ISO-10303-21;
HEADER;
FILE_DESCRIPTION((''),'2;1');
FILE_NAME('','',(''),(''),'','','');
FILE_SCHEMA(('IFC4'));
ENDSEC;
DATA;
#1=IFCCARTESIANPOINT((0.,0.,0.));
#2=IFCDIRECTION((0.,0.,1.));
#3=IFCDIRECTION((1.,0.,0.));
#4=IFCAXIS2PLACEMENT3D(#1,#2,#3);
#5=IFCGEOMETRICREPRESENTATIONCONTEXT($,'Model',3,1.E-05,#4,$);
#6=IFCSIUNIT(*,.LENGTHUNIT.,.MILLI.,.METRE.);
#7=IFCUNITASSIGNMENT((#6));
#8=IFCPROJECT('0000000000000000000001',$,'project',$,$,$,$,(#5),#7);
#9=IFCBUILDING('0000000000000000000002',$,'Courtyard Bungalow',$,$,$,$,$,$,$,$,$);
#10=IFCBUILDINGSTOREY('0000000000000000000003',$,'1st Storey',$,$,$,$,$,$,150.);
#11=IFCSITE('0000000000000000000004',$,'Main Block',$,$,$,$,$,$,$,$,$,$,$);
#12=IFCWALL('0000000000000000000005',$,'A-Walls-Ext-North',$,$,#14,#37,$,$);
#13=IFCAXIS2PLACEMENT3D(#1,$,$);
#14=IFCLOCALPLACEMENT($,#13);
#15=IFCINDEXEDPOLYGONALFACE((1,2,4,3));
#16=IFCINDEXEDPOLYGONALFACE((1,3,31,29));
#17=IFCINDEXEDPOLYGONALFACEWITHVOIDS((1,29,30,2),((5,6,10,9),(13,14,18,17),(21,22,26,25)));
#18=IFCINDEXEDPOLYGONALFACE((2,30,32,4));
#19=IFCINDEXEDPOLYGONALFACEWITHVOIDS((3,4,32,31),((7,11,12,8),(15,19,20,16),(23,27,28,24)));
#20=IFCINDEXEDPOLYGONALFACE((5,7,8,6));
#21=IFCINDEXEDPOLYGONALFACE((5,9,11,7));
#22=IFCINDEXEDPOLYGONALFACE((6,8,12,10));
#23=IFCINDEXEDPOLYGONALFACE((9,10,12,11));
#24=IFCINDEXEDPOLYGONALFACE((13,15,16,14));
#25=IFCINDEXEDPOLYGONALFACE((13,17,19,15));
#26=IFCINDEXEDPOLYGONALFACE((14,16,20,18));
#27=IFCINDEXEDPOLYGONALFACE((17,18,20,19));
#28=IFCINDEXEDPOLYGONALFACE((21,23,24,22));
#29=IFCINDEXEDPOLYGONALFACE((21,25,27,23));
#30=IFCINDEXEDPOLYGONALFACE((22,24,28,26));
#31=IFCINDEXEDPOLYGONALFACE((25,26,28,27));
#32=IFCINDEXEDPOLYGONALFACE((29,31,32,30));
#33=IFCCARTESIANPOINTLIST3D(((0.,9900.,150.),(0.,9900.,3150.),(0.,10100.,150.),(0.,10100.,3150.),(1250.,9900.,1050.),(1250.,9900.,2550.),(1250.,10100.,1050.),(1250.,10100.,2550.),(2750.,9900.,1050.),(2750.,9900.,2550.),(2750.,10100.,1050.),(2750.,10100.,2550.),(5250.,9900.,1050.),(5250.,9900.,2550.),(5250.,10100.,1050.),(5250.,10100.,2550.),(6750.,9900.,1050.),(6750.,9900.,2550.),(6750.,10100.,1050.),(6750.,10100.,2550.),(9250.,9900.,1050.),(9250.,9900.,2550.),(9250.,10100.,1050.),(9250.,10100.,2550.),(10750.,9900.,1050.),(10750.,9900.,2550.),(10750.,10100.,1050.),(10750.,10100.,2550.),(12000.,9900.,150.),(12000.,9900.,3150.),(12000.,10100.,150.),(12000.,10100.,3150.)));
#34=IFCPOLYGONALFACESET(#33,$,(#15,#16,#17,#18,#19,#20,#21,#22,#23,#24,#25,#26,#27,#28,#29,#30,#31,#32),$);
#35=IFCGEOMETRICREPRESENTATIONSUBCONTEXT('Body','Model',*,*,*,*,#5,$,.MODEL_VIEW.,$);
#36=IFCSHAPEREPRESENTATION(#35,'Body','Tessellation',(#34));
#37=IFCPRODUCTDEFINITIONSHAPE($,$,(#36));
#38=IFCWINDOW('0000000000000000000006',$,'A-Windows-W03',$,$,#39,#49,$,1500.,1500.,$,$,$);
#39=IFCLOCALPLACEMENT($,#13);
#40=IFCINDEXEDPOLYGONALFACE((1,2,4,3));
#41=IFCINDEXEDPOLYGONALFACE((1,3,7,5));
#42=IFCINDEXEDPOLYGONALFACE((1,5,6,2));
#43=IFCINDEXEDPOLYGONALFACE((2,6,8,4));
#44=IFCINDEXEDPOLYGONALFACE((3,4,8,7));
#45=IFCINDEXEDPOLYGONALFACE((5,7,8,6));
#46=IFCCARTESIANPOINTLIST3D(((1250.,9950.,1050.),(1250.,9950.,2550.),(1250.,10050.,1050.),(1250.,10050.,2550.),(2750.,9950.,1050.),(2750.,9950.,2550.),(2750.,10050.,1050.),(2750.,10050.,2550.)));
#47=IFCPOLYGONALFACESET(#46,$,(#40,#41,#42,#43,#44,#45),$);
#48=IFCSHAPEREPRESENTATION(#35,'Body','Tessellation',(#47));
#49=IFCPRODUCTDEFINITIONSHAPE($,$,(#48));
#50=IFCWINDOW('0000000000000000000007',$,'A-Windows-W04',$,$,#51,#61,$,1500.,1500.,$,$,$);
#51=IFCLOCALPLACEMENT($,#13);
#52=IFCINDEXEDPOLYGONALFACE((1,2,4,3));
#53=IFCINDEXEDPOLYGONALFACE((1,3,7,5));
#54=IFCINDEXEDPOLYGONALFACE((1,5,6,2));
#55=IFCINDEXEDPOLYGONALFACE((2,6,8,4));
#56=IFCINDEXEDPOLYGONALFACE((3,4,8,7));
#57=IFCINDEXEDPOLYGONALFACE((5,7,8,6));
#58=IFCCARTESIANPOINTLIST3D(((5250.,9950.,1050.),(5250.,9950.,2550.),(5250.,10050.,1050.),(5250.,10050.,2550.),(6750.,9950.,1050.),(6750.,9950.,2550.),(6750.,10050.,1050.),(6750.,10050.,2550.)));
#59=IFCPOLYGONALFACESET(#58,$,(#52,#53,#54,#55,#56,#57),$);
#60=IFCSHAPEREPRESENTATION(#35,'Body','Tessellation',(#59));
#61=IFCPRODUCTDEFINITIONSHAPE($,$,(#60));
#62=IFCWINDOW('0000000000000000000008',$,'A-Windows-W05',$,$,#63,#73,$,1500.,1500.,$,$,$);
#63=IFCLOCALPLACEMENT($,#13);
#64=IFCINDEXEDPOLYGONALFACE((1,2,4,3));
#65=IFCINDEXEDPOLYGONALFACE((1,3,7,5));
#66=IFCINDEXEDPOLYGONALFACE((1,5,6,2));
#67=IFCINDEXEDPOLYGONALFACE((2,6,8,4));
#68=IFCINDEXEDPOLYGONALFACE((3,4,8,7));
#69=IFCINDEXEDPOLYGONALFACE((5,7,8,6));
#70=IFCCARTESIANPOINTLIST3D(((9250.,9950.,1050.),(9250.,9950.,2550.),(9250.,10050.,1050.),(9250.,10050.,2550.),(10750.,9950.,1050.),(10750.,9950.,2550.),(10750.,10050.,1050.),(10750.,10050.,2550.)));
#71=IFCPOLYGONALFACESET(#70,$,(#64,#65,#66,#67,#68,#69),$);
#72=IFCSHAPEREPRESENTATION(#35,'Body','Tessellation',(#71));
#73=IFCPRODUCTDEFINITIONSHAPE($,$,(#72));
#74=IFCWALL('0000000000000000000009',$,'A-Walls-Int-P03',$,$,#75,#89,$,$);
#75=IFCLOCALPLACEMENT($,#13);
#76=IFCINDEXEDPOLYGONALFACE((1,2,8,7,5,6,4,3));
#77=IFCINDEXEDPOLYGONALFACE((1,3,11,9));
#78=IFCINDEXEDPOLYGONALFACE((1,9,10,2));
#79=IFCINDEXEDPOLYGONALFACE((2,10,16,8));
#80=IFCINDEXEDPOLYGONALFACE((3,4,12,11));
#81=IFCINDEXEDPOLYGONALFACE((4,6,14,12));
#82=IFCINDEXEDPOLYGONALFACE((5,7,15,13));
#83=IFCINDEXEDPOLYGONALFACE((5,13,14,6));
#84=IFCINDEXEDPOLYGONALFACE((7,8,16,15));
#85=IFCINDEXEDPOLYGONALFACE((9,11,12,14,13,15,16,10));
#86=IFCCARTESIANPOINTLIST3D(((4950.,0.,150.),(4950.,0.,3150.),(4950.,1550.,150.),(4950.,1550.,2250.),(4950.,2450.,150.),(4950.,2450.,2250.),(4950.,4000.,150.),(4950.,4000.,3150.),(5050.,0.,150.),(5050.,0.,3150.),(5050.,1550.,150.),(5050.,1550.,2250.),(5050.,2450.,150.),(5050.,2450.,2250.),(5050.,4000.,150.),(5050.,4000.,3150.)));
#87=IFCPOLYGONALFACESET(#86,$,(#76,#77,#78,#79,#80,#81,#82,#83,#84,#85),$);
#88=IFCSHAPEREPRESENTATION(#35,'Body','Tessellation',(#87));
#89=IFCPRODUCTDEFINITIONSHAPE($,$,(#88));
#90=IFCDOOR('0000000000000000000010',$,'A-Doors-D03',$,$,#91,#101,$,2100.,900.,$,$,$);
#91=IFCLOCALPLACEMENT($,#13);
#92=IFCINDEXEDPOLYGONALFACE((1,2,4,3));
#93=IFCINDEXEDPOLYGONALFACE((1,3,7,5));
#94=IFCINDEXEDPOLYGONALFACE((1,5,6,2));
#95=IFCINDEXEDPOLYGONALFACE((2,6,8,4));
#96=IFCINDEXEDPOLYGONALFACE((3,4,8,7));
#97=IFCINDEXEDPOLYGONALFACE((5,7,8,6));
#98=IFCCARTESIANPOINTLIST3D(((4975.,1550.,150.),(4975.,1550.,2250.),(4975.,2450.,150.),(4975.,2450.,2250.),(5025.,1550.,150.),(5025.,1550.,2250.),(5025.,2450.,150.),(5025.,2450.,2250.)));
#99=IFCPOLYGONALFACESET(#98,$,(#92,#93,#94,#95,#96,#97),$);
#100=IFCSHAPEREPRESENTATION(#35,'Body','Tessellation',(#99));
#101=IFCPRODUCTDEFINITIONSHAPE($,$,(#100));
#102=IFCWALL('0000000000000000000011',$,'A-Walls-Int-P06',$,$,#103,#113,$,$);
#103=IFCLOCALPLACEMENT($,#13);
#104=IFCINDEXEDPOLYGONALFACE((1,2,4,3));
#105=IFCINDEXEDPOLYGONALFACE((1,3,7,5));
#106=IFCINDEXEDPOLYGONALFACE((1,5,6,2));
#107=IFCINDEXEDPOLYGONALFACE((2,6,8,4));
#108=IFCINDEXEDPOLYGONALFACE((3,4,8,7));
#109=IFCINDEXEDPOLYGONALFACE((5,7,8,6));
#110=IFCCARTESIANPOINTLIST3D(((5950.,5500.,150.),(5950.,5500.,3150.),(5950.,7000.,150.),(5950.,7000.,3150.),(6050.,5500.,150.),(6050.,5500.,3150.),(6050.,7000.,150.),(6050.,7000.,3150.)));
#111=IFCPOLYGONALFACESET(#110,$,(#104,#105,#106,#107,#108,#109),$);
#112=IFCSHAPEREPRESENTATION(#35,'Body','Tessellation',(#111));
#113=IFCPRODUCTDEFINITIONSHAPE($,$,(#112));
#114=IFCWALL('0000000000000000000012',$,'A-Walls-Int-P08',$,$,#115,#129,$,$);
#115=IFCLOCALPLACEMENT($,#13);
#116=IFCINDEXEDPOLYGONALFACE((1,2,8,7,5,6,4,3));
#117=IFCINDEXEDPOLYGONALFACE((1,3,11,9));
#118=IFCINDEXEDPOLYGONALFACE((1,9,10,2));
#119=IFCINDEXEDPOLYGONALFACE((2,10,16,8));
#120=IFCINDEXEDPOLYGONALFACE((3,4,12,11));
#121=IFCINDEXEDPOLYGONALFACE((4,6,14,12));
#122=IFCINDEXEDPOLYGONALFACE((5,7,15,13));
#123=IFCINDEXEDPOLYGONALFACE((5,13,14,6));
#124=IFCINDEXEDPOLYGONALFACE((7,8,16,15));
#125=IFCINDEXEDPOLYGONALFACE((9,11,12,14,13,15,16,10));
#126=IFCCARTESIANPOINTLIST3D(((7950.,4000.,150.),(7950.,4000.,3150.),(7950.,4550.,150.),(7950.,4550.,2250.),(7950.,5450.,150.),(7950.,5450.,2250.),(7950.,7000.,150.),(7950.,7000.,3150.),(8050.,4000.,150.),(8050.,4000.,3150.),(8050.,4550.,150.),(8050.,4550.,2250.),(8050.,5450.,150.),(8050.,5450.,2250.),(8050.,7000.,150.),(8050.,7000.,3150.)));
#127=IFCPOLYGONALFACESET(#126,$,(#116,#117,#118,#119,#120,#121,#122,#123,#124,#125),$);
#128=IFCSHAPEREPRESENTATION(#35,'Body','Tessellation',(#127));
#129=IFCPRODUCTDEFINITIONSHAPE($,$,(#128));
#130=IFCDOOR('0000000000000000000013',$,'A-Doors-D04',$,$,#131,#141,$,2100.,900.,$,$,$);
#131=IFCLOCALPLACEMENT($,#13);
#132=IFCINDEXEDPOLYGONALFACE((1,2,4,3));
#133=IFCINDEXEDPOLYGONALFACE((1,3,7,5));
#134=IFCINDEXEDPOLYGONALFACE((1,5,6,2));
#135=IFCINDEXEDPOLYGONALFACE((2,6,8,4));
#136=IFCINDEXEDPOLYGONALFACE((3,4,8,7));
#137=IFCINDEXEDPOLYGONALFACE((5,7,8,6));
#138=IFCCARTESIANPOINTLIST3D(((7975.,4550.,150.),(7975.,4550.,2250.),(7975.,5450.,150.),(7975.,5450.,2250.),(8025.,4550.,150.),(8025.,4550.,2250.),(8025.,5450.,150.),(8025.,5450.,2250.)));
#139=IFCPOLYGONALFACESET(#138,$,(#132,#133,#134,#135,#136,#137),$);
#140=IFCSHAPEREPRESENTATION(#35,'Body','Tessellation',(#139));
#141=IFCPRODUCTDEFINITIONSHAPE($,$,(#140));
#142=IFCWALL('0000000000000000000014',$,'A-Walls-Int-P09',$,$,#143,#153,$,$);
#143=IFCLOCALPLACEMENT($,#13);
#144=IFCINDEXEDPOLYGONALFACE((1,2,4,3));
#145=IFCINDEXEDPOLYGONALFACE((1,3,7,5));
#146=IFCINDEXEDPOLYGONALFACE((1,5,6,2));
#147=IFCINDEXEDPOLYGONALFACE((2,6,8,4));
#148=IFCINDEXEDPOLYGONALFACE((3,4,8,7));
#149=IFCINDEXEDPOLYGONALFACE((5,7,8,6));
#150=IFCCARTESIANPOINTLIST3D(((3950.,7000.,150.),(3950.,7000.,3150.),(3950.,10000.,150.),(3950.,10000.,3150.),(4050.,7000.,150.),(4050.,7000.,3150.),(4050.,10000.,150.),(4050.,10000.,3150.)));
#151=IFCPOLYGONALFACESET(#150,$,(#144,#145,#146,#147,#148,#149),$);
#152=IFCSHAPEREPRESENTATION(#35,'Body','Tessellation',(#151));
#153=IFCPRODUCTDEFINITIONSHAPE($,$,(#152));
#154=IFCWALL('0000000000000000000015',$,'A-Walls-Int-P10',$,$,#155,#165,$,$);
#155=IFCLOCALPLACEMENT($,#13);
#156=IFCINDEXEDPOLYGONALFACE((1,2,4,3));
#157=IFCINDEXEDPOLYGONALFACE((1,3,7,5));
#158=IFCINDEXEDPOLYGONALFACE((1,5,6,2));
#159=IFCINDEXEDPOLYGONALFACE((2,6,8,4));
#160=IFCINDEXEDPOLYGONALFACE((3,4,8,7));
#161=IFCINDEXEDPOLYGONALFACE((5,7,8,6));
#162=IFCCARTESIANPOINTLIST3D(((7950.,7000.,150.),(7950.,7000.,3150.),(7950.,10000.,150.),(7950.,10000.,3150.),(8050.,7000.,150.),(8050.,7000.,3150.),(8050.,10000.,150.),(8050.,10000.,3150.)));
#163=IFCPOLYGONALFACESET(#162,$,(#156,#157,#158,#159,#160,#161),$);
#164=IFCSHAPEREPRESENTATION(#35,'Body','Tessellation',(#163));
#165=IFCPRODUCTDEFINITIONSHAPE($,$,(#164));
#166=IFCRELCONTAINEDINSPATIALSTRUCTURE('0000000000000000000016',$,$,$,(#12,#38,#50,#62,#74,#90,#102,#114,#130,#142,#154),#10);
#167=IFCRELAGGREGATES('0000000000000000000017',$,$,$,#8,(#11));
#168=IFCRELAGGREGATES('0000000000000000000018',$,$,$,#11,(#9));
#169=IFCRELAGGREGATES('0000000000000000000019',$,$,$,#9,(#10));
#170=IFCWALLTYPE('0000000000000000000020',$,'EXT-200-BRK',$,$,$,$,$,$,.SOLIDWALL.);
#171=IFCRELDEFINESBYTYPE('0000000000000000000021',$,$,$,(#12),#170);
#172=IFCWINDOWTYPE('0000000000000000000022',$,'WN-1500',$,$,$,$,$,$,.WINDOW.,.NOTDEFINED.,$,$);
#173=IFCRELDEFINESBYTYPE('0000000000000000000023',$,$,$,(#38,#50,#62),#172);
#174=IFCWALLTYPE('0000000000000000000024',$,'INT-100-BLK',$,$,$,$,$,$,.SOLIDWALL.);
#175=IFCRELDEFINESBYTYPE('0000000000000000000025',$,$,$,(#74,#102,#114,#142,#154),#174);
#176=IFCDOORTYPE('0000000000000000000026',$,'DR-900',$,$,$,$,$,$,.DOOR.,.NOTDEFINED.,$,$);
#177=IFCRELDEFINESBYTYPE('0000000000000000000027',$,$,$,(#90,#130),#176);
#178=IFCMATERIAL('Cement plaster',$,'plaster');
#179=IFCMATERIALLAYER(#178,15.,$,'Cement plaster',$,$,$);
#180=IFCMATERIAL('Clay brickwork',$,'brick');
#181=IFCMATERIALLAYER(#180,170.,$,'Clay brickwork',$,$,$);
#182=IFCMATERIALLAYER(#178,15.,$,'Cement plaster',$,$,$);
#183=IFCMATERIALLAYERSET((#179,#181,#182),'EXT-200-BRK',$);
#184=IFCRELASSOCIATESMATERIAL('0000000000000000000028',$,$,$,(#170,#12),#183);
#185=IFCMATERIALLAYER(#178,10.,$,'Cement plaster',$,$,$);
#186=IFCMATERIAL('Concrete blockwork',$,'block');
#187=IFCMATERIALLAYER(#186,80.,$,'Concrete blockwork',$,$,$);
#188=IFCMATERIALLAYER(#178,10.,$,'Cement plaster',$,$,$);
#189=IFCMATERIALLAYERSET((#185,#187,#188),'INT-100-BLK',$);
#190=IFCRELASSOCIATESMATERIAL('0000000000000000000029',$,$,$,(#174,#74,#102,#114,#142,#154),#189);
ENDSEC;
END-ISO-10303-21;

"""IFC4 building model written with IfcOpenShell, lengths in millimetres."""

from ifc_helpers import new_model, si_unit, frame, origin_with_axes, place, context, subcontext, project, spatial, indexed_curve, outline, extrude, material, layer, layer_set, layer_usage, type_object, element, fill, save


model = new_model("IFC4")

# Units and contexts
model_context = context("Model", 3, precision=1e-05, world=origin_with_axes())
body_context = subcontext(model_context, "Body", "Model", "MODEL_VIEW")
ifc_project = project(units=[si_unit("LENGTHUNIT", "METRE", prefix="MILLI")], contexts=[model_context])

# Site, building, storey
site = spatial("IfcSite", under=ifc_project, Name="Main Block")
building = spatial("IfcBuilding", under=site, Name="Courtyard Bungalow")
storey = spatial("IfcBuildingStorey", under=building, Name="1st Storey", Elevation=150.0)

# Shared definitions
ifc_material_1 = material(Name="Cement plaster", Category="plaster")
ifc_layer_1 = layer(ifc_material_1, 15.0, Name="Cement plaster")
ifc_material_2 = material(Name="Clay brickwork", Category="brick")
ifc_layer_2 = layer(ifc_material_2, 170.0, Name="Clay brickwork")
ifc_layer_3 = layer(ifc_material_1, 15.0, Name="Cement plaster")
ifc_layer_set_1 = layer_set([ifc_layer_1, ifc_layer_2, ifc_layer_3], Name="EXT-200-BRK")
wall_type_1 = type_object("IfcWallType", Name="EXT-200-BRK", PredefinedType="SOLIDWALL", material=ifc_layer_set_1)

# Wall, openings, windows
ifc_layer_usage_1 = layer_usage(ifc_layer_set_1, "AXIS2", "POSITIVE", 0.0)
wall_1_placement = place(None, frame((12000.0, 10100.0, 150.0), z_axis=(0.0, 0.0, 1.0), x_axis=(-1.0, 0.0, 0.0)))
wall_1 = element("IfcWall", 1, at=wall_1_placement, inside=storey, type_object=wall_type_1, material=ifc_layer_usage_1, Name="A-Walls-Ext-North", context=body_context, shape_type="SweptSolid", body=[
    extrude(outline(indexed_curve([(0.0, 0.0), (0.0, 200.0), (12000.0, 200.0), (12000.0, 0.0), (0.0, 0.0)], self_intersect=False)), origin_with_axes(), (0.0, 0.0, 1.0), 3000.0),
])
opening_1_placement = place(wall_1_placement, frame((10000.0, 100.0, 900.0), z_axis=(0.0, 0.0, 1.0), x_axis=(1.0, 0.0, 0.0)))
opening_1 = element("IfcOpeningElement", 2, at=opening_1_placement, cuts=wall_1, PredefinedType="OPENING", context=body_context, shape_type="SweptSolid", body=[
    extrude(outline(indexed_curve([(-750.0, -150.0), (750.0, -150.0), (750.0, 150.0), (-750.0, 150.0)])), None, (0.0, 0.0, 1.0), 1500.0),
])
opening_2_placement = place(wall_1_placement, frame((6000.0, 100.0, 900.0), z_axis=(0.0, 0.0, 1.0), x_axis=(1.0, 0.0, 0.0)))
opening_2 = element("IfcOpeningElement", 3, at=opening_2_placement, cuts=wall_1, PredefinedType="OPENING", context=body_context, shape_type="SweptSolid", body=[
    extrude(outline(indexed_curve([(-750.0, -150.0), (750.0, -150.0), (750.0, 150.0), (-750.0, 150.0)])), None, (0.0, 0.0, 1.0), 1500.0),
])
opening_3_placement = place(wall_1_placement, frame((2000.0, 100.0, 900.0), z_axis=(0.0, 0.0, 1.0), x_axis=(1.0, 0.0, 0.0)))
opening_3 = element("IfcOpeningElement", 4, at=opening_3_placement, cuts=wall_1, PredefinedType="OPENING", context=body_context, shape_type="SweptSolid", body=[
    extrude(outline(indexed_curve([(-750.0, -150.0), (750.0, -150.0), (750.0, 150.0), (-750.0, 150.0)])), None, (0.0, 0.0, 1.0), 1500.0),
])
window_type_1 = type_object("IfcWindowType", Name="WN-1500", PartitioningType="NOTDEFINED", PredefinedType="WINDOW")
window_1_placement = place(None, frame((2000.0, 10000.0, 1050.0), z_axis=(0.0, 0.0, 1.0), x_axis=(-1.0, 0.0, 0.0)))
window_1 = element("IfcWindow", 5, at=window_1_placement, inside=storey, type_object=window_type_1, Name="A-Windows-W03", OverallHeight=1500.0, OverallWidth=1500.0, context=body_context, shape_type="SweptSolid", body=[
    extrude(outline(indexed_curve([(-750.0, -50.0), (750.0, -50.0), (750.0, 50.0), (-750.0, 50.0)])), None, (0.0, 0.0, 1.0), 1500.0),
])
fill(opening_1, window_1)
window_2_placement = place(None, frame((6000.0, 10000.0, 1050.0), z_axis=(0.0, 0.0, 1.0), x_axis=(-1.0, 0.0, 0.0)))
window_2 = element("IfcWindow", 6, at=window_2_placement, inside=storey, type_object=window_type_1, Name="A-Windows-W04", OverallHeight=1500.0, OverallWidth=1500.0, context=body_context, shape_type="SweptSolid", body=[
    extrude(outline(indexed_curve([(-750.0, -50.0), (750.0, -50.0), (750.0, 50.0), (-750.0, 50.0)])), None, (0.0, 0.0, 1.0), 1500.0),
])
fill(opening_2, window_2)
window_3_placement = place(None, frame((10000.0, 10000.0, 1050.0), z_axis=(0.0, 0.0, 1.0), x_axis=(-1.0, 0.0, 0.0)))
window_3 = element("IfcWindow", 7, at=window_3_placement, inside=storey, type_object=window_type_1, Name="A-Windows-W05", OverallHeight=1500.0, OverallWidth=1500.0, context=body_context, shape_type="SweptSolid", body=[
    extrude(outline(indexed_curve([(-750.0, -50.0), (750.0, -50.0), (750.0, 50.0), (-750.0, 50.0)])), None, (0.0, 0.0, 1.0), 1500.0),
])
fill(opening_3, window_3)

# Wall, opening, door
ifc_layer_4 = layer(ifc_material_1, 10.0, Name="Cement plaster")
ifc_material_3 = material(Name="Concrete blockwork", Category="block")
ifc_layer_5 = layer(ifc_material_3, 80.0, Name="Concrete blockwork")
ifc_layer_6 = layer(ifc_material_1, 10.0, Name="Cement plaster")
ifc_layer_set_2 = layer_set([ifc_layer_4, ifc_layer_5, ifc_layer_6], Name="INT-100-BLK")
ifc_layer_usage_2 = layer_usage(ifc_layer_set_2, "AXIS2", "POSITIVE", 0.0)
wall_type_2 = type_object("IfcWallType", Name="INT-100-BLK", PredefinedType="SOLIDWALL", material=ifc_layer_set_2)
wall_2_placement = place(None, frame((5050.0, 0.0, 150.0), z_axis=(0.0, 0.0, 1.0), x_axis=(0.0, 1.0, 0.0)))
wall_2 = element("IfcWall", 8, at=wall_2_placement, inside=storey, type_object=wall_type_2, material=ifc_layer_usage_2, Name="A-Walls-Int-P03", context=body_context, shape_type="SweptSolid", body=[
    extrude(outline(indexed_curve([(0.0, 0.0), (0.0, 100.0), (4000.0, 100.0), (4000.0, 0.0), (0.0, 0.0)], self_intersect=False)), origin_with_axes(), (0.0, 0.0, 1.0), 3000.0),
])
opening_4_placement = place(wall_2_placement, frame((2000.0, 50.0, 0.0), z_axis=(0.0, 0.0, 1.0), x_axis=(1.0, 0.0, 0.0)))
opening_4 = element("IfcOpeningElement", 9, at=opening_4_placement, cuts=wall_2, PredefinedType="OPENING", context=body_context, shape_type="SweptSolid", body=[
    extrude(outline(indexed_curve([(-450.0, -100.0), (450.0, -100.0), (450.0, 100.0), (-450.0, 100.0)])), None, (0.0, 0.0, 1.0), 2100.0),
])
door_type_1 = type_object("IfcDoorType", Name="DR-900", OperationType="NOTDEFINED", PredefinedType="DOOR")
door_1_placement = place(None, frame((5000.0, 2000.0, 150.0), z_axis=(0.0, 0.0, 1.0), x_axis=(0.0, 1.0, 0.0)))
door_1 = element("IfcDoor", 10, at=door_1_placement, inside=storey, type_object=door_type_1, Name="A-Doors-D03", OverallHeight=2100.0, OverallWidth=900.0, context=body_context, shape_type="SweptSolid", body=[
    extrude(outline(indexed_curve([(-450.0, -25.0), (450.0, -25.0), (450.0, 25.0), (-450.0, 25.0)])), None, (0.0, 0.0, 1.0), 2100.0),
])
fill(opening_4, door_1)

# Wall
ifc_layer_usage_3 = layer_usage(ifc_layer_set_2, "AXIS2", "POSITIVE", 0.0)
wall_3_placement = place(None, frame((6050.0, 5500.0, 150.0), z_axis=(0.0, 0.0, 1.0), x_axis=(0.0, 1.0, 0.0)))
element("IfcWall", 11, at=wall_3_placement, inside=storey, type_object=wall_type_2, material=ifc_layer_usage_3, Name="A-Walls-Int-P06", context=body_context, shape_type="SweptSolid", body=[
    extrude(outline(indexed_curve([(0.0, 0.0), (0.0, 100.0), (1500.0, 100.0), (1500.0, 0.0), (0.0, 0.0)], self_intersect=False)), origin_with_axes(), (0.0, 0.0, 1.0), 3000.0),
])

# Wall, opening, door
ifc_layer_usage_4 = layer_usage(ifc_layer_set_2, "AXIS2", "POSITIVE", 0.0)
wall_4_placement = place(None, frame((8050.0, 4000.0, 150.0), z_axis=(0.0, 0.0, 1.0), x_axis=(0.0, 1.0, 0.0)))
wall_4 = element("IfcWall", 12, at=wall_4_placement, inside=storey, type_object=wall_type_2, material=ifc_layer_usage_4, Name="A-Walls-Int-P08", context=body_context, shape_type="SweptSolid", body=[
    extrude(outline(indexed_curve([(0.0, 0.0), (0.0, 100.0), (3000.0, 100.0), (3000.0, 0.0), (0.0, 0.0)], self_intersect=False)), origin_with_axes(), (0.0, 0.0, 1.0), 3000.0),
])
opening_5_placement = place(wall_4_placement, frame((1000.0, 50.0, 0.0), z_axis=(0.0, 0.0, 1.0), x_axis=(1.0, 0.0, 0.0)))
opening_5 = element("IfcOpeningElement", 13, at=opening_5_placement, cuts=wall_4, PredefinedType="OPENING", context=body_context, shape_type="SweptSolid", body=[
    extrude(outline(indexed_curve([(-450.0, -100.0), (450.0, -100.0), (450.0, 100.0), (-450.0, 100.0)])), None, (0.0, 0.0, 1.0), 2100.0),
])
door_2_placement = place(None, frame((8000.0, 5000.0, 150.0), z_axis=(0.0, 0.0, 1.0), x_axis=(0.0, 1.0, 0.0)))
door_2 = element("IfcDoor", 14, at=door_2_placement, inside=storey, type_object=door_type_1, Name="A-Doors-D04", OverallHeight=2100.0, OverallWidth=900.0, context=body_context, shape_type="SweptSolid", body=[
    extrude(outline(indexed_curve([(-450.0, -25.0), (450.0, -25.0), (450.0, 25.0), (-450.0, 25.0)])), None, (0.0, 0.0, 1.0), 2100.0),
])
fill(opening_5, door_2)

# Walls
ifc_layer_usage_5 = layer_usage(ifc_layer_set_2, "AXIS2", "POSITIVE", 0.0)
wall_5_placement = place(None, frame((4050.0, 7000.0, 150.0), z_axis=(0.0, 0.0, 1.0), x_axis=(0.0, 1.0, 0.0)))
element("IfcWall", 15, at=wall_5_placement, inside=storey, type_object=wall_type_2, material=ifc_layer_usage_5, Name="A-Walls-Int-P09", context=body_context, shape_type="SweptSolid", body=[
    extrude(outline(indexed_curve([(0.0, 0.0), (0.0, 100.0), (3000.0, 100.0), (3000.0, 0.0), (0.0, 0.0)], self_intersect=False)), origin_with_axes(), (0.0, 0.0, 1.0), 3000.0),
])
ifc_layer_usage_6 = layer_usage(ifc_layer_set_2, "AXIS2", "POSITIVE", 0.0)
wall_6_placement = place(None, frame((8050.0, 7000.0, 150.0), z_axis=(0.0, 0.0, 1.0), x_axis=(0.0, 1.0, 0.0)))
element("IfcWall", 16, at=wall_6_placement, inside=storey, type_object=wall_type_2, material=ifc_layer_usage_6, Name="A-Walls-Int-P10", context=body_context, shape_type="SweptSolid", body=[
    extrude(outline(indexed_curve([(0.0, 0.0), (0.0, 100.0), (3000.0, 100.0), (3000.0, 0.0), (0.0, 0.0)], self_intersect=False)), origin_with_axes(), (0.0, 0.0, 1.0), 3000.0),
])

save(model, "model.ifc")
